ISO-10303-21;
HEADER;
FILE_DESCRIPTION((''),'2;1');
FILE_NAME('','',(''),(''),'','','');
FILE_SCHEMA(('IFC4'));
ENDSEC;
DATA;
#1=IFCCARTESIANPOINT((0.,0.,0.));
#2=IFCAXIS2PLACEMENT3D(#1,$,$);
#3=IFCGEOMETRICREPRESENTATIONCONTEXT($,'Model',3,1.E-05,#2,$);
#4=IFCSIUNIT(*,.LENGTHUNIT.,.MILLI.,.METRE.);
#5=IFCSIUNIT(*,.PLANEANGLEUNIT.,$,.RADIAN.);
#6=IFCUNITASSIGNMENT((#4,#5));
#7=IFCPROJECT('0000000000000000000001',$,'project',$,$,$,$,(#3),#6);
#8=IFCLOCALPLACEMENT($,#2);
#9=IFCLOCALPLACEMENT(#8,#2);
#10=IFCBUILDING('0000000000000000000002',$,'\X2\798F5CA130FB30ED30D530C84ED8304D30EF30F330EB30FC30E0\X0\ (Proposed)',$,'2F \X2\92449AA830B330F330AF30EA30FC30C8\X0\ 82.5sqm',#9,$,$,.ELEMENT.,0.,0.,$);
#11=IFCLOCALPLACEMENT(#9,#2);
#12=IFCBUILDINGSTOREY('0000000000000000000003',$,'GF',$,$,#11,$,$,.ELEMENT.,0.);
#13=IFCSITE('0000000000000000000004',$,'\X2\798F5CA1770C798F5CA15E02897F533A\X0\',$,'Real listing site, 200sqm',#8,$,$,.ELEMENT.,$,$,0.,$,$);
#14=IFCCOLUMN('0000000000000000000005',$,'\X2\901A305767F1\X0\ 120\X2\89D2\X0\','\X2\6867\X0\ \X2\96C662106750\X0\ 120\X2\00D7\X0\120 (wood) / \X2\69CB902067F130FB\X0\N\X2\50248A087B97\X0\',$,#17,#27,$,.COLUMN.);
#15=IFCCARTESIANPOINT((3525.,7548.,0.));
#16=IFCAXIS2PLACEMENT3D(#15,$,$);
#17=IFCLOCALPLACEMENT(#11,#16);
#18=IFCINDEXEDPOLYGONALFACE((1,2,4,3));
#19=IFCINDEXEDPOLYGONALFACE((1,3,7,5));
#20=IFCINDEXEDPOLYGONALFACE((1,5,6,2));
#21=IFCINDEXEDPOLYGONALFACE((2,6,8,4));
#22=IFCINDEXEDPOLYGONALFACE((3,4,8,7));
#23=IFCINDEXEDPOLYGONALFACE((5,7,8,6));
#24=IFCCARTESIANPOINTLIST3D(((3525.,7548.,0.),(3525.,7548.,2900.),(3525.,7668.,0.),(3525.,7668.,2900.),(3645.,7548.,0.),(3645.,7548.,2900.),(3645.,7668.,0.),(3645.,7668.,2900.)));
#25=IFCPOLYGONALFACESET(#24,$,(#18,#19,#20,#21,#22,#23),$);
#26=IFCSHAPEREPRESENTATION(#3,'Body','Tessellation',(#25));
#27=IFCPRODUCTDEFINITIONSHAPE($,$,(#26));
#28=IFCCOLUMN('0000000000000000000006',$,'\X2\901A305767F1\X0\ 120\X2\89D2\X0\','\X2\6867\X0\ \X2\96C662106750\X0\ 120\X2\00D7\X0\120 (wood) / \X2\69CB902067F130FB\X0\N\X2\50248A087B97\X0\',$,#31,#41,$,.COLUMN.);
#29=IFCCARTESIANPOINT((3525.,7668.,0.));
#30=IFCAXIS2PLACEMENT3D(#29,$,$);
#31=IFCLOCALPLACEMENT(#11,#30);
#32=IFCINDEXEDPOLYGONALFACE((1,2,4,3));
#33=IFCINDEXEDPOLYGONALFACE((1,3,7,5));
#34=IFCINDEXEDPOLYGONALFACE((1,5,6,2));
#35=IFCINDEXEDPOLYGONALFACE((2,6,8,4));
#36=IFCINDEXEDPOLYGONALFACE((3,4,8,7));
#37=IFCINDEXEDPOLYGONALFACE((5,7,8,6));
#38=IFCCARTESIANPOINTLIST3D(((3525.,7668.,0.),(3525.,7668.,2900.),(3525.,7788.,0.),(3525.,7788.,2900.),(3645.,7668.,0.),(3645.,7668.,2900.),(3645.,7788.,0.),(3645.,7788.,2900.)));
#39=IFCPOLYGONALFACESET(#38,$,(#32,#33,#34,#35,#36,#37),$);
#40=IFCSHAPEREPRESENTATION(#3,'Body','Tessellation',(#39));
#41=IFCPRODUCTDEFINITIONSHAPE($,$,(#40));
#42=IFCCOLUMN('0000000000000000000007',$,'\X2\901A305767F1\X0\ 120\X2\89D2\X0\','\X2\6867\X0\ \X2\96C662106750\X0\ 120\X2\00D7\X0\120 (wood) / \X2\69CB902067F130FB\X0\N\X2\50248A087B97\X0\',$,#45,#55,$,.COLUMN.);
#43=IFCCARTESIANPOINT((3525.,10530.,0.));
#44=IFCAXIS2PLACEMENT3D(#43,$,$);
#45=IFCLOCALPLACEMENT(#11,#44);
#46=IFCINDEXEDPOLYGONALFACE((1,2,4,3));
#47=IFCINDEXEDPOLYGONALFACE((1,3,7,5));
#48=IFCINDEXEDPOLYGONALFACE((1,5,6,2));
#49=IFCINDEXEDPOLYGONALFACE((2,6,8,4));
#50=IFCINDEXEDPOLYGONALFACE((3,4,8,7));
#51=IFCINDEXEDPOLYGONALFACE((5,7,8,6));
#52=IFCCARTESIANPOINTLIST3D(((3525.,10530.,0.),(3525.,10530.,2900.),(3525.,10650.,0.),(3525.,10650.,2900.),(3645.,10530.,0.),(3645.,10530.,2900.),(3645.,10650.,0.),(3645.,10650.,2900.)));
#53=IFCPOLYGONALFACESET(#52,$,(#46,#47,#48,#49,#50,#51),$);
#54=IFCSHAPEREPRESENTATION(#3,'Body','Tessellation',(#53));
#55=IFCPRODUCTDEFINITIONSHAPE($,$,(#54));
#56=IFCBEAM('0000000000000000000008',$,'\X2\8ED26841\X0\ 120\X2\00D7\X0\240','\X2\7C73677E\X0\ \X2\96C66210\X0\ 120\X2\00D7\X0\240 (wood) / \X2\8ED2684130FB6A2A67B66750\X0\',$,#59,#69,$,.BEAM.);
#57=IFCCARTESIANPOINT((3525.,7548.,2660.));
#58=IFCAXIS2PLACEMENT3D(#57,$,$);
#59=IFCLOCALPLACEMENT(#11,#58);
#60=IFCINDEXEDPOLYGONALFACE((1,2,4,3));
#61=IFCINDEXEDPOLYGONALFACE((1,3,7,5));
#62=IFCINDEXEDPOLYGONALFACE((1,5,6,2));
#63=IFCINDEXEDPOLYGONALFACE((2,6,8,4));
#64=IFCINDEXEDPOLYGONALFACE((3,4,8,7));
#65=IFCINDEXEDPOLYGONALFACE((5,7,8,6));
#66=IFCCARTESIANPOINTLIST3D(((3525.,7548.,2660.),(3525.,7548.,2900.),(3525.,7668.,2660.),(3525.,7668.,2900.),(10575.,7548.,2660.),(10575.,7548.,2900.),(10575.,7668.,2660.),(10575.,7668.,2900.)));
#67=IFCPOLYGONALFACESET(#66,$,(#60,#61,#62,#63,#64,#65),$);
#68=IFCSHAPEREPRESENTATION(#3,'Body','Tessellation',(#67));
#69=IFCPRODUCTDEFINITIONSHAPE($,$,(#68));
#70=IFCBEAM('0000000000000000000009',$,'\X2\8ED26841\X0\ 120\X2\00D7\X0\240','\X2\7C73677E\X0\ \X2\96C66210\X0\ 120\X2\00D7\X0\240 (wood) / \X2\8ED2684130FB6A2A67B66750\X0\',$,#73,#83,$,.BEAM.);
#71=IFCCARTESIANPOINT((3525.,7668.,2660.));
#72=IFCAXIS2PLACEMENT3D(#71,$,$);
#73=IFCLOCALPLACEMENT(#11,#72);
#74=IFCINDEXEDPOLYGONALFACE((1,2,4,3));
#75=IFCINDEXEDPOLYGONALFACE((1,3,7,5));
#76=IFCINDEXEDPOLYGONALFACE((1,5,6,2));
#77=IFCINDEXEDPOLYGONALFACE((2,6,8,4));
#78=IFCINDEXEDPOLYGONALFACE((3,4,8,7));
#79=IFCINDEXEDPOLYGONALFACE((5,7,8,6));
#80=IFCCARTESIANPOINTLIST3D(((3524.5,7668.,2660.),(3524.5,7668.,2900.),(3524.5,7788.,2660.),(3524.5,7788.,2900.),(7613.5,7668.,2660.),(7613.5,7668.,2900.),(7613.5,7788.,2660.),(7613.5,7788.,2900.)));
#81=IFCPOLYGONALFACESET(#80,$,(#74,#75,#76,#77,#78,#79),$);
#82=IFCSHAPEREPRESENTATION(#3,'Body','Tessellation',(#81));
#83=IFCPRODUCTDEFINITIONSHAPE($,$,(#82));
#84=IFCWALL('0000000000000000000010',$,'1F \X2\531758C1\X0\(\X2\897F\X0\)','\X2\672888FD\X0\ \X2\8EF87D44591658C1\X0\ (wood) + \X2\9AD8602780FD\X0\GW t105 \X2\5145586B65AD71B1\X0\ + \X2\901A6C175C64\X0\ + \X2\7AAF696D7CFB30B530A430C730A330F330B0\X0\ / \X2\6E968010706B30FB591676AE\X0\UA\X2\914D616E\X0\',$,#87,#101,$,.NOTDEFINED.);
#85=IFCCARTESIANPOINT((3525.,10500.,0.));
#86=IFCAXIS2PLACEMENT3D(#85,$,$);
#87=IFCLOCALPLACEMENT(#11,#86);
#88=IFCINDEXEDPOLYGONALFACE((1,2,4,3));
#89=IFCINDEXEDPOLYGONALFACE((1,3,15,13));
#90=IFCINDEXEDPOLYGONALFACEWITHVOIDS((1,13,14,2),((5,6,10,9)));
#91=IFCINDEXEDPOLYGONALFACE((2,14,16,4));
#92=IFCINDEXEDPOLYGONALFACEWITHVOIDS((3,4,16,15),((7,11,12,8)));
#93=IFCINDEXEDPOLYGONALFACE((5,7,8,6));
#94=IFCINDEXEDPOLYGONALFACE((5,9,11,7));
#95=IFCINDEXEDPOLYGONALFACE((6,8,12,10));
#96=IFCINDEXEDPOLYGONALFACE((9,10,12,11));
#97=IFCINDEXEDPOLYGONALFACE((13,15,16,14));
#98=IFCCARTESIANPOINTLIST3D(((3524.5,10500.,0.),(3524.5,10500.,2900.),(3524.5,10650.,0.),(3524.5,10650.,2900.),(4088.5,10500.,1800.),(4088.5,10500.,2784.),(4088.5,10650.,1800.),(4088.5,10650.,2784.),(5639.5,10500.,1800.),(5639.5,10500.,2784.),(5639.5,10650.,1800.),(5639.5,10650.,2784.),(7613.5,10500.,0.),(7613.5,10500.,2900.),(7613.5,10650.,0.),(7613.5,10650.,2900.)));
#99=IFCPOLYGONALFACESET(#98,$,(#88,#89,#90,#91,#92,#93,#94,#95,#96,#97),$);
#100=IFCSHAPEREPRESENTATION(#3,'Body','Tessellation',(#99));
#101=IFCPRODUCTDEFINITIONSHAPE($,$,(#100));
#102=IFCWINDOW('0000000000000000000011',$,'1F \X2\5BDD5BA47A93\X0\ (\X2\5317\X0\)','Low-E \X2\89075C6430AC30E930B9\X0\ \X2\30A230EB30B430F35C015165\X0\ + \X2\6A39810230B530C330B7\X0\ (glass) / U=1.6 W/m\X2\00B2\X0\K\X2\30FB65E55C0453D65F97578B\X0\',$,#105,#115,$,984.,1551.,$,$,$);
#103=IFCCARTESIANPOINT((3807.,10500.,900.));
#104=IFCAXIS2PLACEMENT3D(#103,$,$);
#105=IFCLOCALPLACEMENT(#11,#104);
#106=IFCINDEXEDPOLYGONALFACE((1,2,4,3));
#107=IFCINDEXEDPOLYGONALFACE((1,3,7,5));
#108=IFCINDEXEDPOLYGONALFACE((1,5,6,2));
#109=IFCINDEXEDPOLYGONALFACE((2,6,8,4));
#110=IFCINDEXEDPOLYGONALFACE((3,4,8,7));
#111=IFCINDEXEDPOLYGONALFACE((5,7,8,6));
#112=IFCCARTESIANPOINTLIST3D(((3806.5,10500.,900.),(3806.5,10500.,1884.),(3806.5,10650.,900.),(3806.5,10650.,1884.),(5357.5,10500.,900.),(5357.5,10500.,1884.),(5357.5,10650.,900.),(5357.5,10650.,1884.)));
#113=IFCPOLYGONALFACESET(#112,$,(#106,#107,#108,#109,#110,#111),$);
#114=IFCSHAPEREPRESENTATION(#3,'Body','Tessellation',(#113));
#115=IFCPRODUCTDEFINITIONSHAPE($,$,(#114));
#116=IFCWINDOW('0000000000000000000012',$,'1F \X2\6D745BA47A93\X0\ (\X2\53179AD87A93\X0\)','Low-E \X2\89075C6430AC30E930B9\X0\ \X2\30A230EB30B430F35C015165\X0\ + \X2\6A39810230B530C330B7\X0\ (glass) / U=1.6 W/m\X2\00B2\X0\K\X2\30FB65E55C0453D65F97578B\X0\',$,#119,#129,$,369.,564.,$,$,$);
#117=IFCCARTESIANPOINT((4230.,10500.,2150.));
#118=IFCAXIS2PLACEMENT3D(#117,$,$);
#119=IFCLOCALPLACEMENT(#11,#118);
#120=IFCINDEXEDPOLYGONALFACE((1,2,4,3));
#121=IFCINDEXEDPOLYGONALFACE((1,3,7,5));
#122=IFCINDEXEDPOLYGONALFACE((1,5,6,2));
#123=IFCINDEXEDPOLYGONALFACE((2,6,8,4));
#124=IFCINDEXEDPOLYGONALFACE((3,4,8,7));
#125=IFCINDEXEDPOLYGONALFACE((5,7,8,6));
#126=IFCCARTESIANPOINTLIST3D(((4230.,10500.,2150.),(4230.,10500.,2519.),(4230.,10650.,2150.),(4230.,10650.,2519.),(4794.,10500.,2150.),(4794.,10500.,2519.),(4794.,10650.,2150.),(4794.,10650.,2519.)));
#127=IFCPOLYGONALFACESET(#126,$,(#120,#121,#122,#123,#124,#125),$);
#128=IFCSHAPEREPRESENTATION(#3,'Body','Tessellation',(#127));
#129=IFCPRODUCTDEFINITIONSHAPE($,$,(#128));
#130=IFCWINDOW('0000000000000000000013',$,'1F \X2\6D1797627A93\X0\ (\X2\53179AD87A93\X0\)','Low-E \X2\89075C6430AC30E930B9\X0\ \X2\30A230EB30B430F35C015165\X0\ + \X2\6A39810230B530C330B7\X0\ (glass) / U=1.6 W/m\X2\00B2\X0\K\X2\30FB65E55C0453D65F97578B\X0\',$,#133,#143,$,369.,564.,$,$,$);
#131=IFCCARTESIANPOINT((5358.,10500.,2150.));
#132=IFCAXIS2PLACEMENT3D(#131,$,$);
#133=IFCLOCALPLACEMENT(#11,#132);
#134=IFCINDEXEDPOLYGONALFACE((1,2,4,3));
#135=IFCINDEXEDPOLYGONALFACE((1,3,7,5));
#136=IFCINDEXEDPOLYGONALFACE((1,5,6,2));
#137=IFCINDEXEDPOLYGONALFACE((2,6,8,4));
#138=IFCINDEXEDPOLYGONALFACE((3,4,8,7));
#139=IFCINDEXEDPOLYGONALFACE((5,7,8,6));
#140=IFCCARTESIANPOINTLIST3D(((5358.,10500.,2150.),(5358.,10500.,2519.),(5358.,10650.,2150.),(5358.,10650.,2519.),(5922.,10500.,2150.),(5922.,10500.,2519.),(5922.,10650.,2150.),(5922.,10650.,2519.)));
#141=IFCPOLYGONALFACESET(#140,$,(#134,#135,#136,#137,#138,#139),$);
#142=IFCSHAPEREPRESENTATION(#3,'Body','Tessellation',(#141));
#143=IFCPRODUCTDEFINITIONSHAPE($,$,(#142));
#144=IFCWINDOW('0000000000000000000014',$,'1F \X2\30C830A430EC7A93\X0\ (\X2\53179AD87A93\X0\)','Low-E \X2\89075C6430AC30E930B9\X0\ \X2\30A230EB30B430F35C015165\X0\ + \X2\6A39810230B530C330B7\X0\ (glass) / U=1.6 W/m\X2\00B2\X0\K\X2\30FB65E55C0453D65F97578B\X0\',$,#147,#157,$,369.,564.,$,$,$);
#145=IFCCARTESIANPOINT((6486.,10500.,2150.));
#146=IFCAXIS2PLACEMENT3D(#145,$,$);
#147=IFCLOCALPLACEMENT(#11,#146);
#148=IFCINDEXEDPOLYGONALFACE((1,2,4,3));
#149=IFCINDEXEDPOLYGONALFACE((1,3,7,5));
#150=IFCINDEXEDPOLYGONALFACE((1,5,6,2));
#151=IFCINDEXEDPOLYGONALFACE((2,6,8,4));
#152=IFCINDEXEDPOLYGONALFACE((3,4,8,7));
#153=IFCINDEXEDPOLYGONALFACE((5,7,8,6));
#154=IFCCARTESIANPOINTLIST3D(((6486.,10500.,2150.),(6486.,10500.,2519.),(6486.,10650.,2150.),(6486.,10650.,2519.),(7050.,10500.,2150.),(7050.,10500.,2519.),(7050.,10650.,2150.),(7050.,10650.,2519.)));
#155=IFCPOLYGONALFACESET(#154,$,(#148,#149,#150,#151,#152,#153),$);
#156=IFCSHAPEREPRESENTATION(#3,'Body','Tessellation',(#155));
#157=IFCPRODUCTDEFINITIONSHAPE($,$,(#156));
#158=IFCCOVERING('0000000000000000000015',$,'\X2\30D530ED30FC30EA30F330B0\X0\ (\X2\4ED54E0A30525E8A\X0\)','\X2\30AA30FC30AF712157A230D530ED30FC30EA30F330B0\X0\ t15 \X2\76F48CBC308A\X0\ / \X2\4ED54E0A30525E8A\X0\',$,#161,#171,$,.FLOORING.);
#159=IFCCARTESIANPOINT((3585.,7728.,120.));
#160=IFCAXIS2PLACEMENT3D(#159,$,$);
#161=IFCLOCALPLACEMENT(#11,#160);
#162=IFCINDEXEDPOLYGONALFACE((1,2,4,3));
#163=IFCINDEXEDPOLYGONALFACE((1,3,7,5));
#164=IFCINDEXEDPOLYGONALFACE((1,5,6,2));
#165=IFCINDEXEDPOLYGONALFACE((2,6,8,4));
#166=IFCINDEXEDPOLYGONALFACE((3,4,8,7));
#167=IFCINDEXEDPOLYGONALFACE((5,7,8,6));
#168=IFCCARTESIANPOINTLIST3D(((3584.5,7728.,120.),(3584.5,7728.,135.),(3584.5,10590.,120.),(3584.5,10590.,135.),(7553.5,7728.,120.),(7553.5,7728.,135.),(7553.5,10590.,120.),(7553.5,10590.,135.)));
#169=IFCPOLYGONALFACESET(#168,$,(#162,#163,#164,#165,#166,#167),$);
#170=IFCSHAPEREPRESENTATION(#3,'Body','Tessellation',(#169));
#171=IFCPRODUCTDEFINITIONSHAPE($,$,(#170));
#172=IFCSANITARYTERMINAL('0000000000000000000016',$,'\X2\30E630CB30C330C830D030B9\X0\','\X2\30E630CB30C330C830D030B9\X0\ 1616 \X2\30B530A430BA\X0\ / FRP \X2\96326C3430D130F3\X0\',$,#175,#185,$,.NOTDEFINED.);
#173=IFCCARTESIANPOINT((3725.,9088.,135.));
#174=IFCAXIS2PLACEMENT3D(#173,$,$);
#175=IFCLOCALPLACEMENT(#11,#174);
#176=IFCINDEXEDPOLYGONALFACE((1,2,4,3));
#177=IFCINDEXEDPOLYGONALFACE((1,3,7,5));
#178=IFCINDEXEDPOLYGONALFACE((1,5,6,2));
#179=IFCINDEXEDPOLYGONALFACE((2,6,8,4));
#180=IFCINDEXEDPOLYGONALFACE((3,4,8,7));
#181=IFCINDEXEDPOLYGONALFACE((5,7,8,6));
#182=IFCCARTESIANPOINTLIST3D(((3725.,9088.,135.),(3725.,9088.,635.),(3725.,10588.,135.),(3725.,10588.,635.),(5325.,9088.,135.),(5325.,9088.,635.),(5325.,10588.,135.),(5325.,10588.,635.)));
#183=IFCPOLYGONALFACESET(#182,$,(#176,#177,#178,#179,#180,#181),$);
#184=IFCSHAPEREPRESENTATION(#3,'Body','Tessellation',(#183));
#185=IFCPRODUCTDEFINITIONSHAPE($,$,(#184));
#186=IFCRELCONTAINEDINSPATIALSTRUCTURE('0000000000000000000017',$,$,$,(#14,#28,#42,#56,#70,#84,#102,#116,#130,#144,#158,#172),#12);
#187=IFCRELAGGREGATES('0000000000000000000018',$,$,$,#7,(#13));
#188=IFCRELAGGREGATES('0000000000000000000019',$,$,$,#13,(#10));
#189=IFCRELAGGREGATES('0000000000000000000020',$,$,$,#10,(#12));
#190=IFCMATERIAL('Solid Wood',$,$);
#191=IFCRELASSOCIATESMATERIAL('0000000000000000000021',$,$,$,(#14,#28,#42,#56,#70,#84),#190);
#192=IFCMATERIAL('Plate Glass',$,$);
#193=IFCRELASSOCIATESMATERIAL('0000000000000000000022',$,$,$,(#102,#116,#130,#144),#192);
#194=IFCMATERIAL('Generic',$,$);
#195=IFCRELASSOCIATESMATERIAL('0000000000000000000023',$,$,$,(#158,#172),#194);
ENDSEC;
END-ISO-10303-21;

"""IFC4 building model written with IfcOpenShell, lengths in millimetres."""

from ifc_helpers import new_model, si_unit, frame, frame_2d, origin, place, context, project, spatial, rectangle, extrude, material, element, fill, save


model = new_model("IFC4")

# Units and contexts
model_context = context("Model", 3, precision=1e-05, world=origin())
ifc_project = project(units=[si_unit("LENGTHUNIT", "METRE", prefix="MILLI"), si_unit("PLANEANGLEUNIT", "RADIAN")], contexts=[model_context])

# Site, building, storey
site_placement = place(None, origin())
site = spatial("IfcSite", under=ifc_project, at=site_placement, Name="福岡県福岡市西区", ObjectType="Real listing site, 200sqm", CompositionType="ELEMENT", RefElevation=0.0)
building_placement = place(site_placement, origin())
building = spatial("IfcBuilding", under=site, at=building_placement, Name="福岡・ロフト付きワンルーム (Proposed)", ObjectType="2F 鉄骨コンクリート 82.5sqm", CompositionType="ELEMENT", ElevationOfRefHeight=0.0, ElevationOfTerrain=0.0)
storey_placement = place(building_placement, origin())
storey = spatial("IfcBuildingStorey", under=building, at=storey_placement, Name="GF", CompositionType="ELEMENT", Elevation=0.0)

# Columns
ifc_material_1 = material(Name="Solid Wood")
column_1_placement = place(storey_placement, frame((3525.0, 7548.0, 0.0)))
element("IfcColumn", 1, at=column_1_placement, inside=storey, material=ifc_material_1, Name="通し柱 120角", Description="桧 集成材 120×120 (wood) / 構造柱・N値計算", PredefinedType="COLUMN", context=model_context, shape_type="SweptSolid", body=[
    extrude(rectangle(XDim=120.0, YDim=120.0, at=frame_2d((60.0, 60.0))), frame((3525.0, 7548.0, 0.0)), (0.0, 0.0, 1.0), 2900.0),
])
column_2_placement = place(storey_placement, frame((3525.0, 7668.0, 0.0)))
element("IfcColumn", 2, at=column_2_placement, inside=storey, material=ifc_material_1, Name="通し柱 120角", Description="桧 集成材 120×120 (wood) / 構造柱・N値計算", PredefinedType="COLUMN", context=model_context, shape_type="SweptSolid", body=[
    extrude(rectangle(XDim=120.0, YDim=120.0, at=frame_2d((60.0, 60.0))), frame((3525.0, 7668.0, 0.0)), (0.0, 0.0, 1.0), 2900.0),
])
column_3_placement = place(storey_placement, frame((3525.0, 10530.0, 0.0)))
element("IfcColumn", 3, at=column_3_placement, inside=storey, material=ifc_material_1, Name="通し柱 120角", Description="桧 集成材 120×120 (wood) / 構造柱・N値計算", PredefinedType="COLUMN", context=model_context, shape_type="SweptSolid", body=[
    extrude(rectangle(XDim=120.0, YDim=120.0, at=frame_2d((60.0, 60.0))), frame((3525.0, 10530.0, 0.0)), (0.0, 0.0, 1.0), 2900.0),
])

# Beams
beam_1_placement = place(storey_placement, frame((3525.0, 7548.0, 2660.0)))
element("IfcBeam", 4, at=beam_1_placement, inside=storey, material=ifc_material_1, Name="軒桁 120×240", Description="米松 集成 120×240 (wood) / 軒桁・横架材", PredefinedType="BEAM", context=model_context, shape_type="SweptSolid", body=[
    extrude(rectangle(XDim=7050.0, YDim=120.0, at=frame_2d((3525.0, 60.0))), frame((3525.0, 7548.0, 2660.0)), (0.0, 0.0, 1.0), 240.0),
])
beam_2_placement = place(storey_placement, frame((3525.0, 7668.0, 2660.0)))
element("IfcBeam", 5, at=beam_2_placement, inside=storey, material=ifc_material_1, Name="軒桁 120×240", Description="米松 集成 120×240 (wood) / 軒桁・横架材", PredefinedType="BEAM", context=model_context, shape_type="SweptSolid", body=[
    extrude(rectangle(XDim=4089.0, YDim=120.0, at=frame_2d((2044.0, 60.0))), frame((3525.0, 7668.0, 2660.0)), (0.0, 0.0, 1.0), 240.0),
])

# Wall, openings, windows
wall_1_placement = place(storey_placement, frame((3525.0, 10500.0, 0.0)))
wall_1 = element("IfcWall", 6, at=wall_1_placement, inside=storey, material=ifc_material_1, Name="1F 北壁(西)", Description="木製 軸組外壁 (wood) + 高性能GW t105 充填断熱 + 通気層 + 窯業系サイディング / 準耐火・外皮UA配慮", PredefinedType="NOTDEFINED", context=model_context, shape_type="SweptSolid", body=[
    extrude(rectangle(XDim=4089.0, YDim=150.0, at=frame_2d((2044.0, 75.0))), frame((3525.0, 10500.0, 0.0)), (0.0, 0.0, 1.0), 2900.0),
])
opening_1_placement = place(storey_placement, frame((3807.0, 10500.0, 900.0)))
opening_1 = element("IfcOpeningElement", 7, at=opening_1_placement, cuts=wall_1, PredefinedType="NOTDEFINED", context=model_context, shape_type="SweptSolid", body=[
    extrude(rectangle(XDim=1551.0, YDim=150.0, at=frame_2d((775.0, 75.0))), frame((3807.0, 10500.0, 900.0)), (0.0, 0.0, 1.0), 984.0),
])
opening_2_placement = place(storey_placement, frame((4230.0, 10500.0, 2150.0)))
opening_2 = element("IfcOpeningElement", 8, at=opening_2_placement, cuts=wall_1, PredefinedType="NOTDEFINED", context=model_context, shape_type="SweptSolid", body=[
    extrude(rectangle(XDim=564.0, YDim=150.0, at=frame_2d((282.0, 75.0))), frame((4230.0, 10500.0, 2150.0)), (0.0, 0.0, 1.0), 369.0),
])
opening_3_placement = place(storey_placement, frame((5358.0, 10500.0, 2150.0)))
opening_3 = element("IfcOpeningElement", 9, at=opening_3_placement, cuts=wall_1, PredefinedType="NOTDEFINED", context=model_context, shape_type="SweptSolid", body=[
    extrude(rectangle(XDim=564.0, YDim=150.0, at=frame_2d((282.0, 75.0))), frame((5358.0, 10500.0, 2150.0)), (0.0, 0.0, 1.0), 369.0),
])
opening_4_placement = place(storey_placement, frame((6486.0, 10500.0, 2150.0)))
opening_4 = element("IfcOpeningElement", 10, at=opening_4_placement, cuts=wall_1, PredefinedType="NOTDEFINED", context=model_context, shape_type="SweptSolid", body=[
    extrude(rectangle(XDim=564.0, YDim=150.0, at=frame_2d((282.0, 75.0))), frame((6486.0, 10500.0, 2150.0)), (0.0, 0.0, 1.0), 369.0),
])
ifc_material_2 = material(Name="Plate Glass")
window_1_placement = place(storey_placement, frame((3807.0, 10500.0, 900.0)))
window_1 = element("IfcWindow", 11, at=window_1_placement, inside=storey, material=ifc_material_2, Name="1F 寝室窓 (北)", Description="Low-E 複層ガラス アルゴン封入 + 樹脂サッシ (glass) / U=1.6 W/m²K・日射取得型", OverallHeight=984.0, OverallWidth=1551.0, context=model_context, shape_type="SweptSolid", body=[
    extrude(rectangle(XDim=1551.0, YDim=150.0, at=frame_2d((775.0, 75.0))), frame((3807.0, 10500.0, 900.0)), (0.0, 0.0, 1.0), 984.0),
])
fill(opening_1, window_1)
window_2_placement = place(storey_placement, frame((4230.0, 10500.0, 2150.0)))
window_2 = element("IfcWindow", 12, at=window_2_placement, inside=storey, material=ifc_material_2, Name="1F 浴室窓 (北高窓)", Description="Low-E 複層ガラス アルゴン封入 + 樹脂サッシ (glass) / U=1.6 W/m²K・日射取得型", OverallHeight=369.0, OverallWidth=564.0, context=model_context, shape_type="SweptSolid", body=[
    extrude(rectangle(XDim=564.0, YDim=150.0, at=frame_2d((282.0, 75.0))), frame((4230.0, 10500.0, 2150.0)), (0.0, 0.0, 1.0), 369.0),
])
fill(opening_2, window_2)
window_3_placement = place(storey_placement, frame((5358.0, 10500.0, 2150.0)))
window_3 = element("IfcWindow", 13, at=window_3_placement, inside=storey, material=ifc_material_2, Name="1F 洗面窓 (北高窓)", Description="Low-E 複層ガラス アルゴン封入 + 樹脂サッシ (glass) / U=1.6 W/m²K・日射取得型", OverallHeight=369.0, OverallWidth=564.0, context=model_context, shape_type="SweptSolid", body=[
    extrude(rectangle(XDim=564.0, YDim=150.0, at=frame_2d((282.0, 75.0))), frame((5358.0, 10500.0, 2150.0)), (0.0, 0.0, 1.0), 369.0),
])
fill(opening_3, window_3)
window_4_placement = place(storey_placement, frame((6486.0, 10500.0, 2150.0)))
window_4 = element("IfcWindow", 14, at=window_4_placement, inside=storey, material=ifc_material_2, Name="1F トイレ窓 (北高窓)", Description="Low-E 複層ガラス アルゴン封入 + 樹脂サッシ (glass) / U=1.6 W/m²K・日射取得型", OverallHeight=369.0, OverallWidth=564.0, context=model_context, shape_type="SweptSolid", body=[
    extrude(rectangle(XDim=564.0, YDim=150.0, at=frame_2d((282.0, 75.0))), frame((6486.0, 10500.0, 2150.0)), (0.0, 0.0, 1.0), 369.0),
])
fill(opening_4, window_4)

# Covering
ifc_material_3 = material(Name="Generic")
covering_placement = place(storey_placement, frame((3585.0, 7728.0, 120.0)))
element("IfcCovering", 15, at=covering_placement, inside=storey, material=ifc_material_3, Name="フローリング (仕上げ床)", Description="オーク無垢フローリング t15 直貼り / 仕上げ床", PredefinedType="FLOORING", context=model_context, shape_type="SweptSolid", body=[
    extrude(rectangle(XDim=3969.0, YDim=2862.0, at=frame_2d((1984.0, 1431.0))), frame((3585.0, 7728.0, 120.0)), (0.0, 0.0, 1.0), 15.0),
])

# Sanitary terminal
sanitary_terminal_placement = place(storey_placement, frame((3725.0, 9088.0, 135.0)))
element("IfcSanitaryTerminal", 16, at=sanitary_terminal_placement, inside=storey, material=ifc_material_3, Name="ユニットバス", Description="ユニットバス 1616 サイズ / FRP 防水パン", PredefinedType="NOTDEFINED", context=model_context, shape_type="SweptSolid", body=[
    extrude(rectangle(XDim=1600.0, YDim=1500.0, at=frame_2d((800.0, 750.0))), frame((3725.0, 9088.0, 135.0)), (0.0, 0.0, 1.0), 500.0),
])

save(model, "model.ifc")
